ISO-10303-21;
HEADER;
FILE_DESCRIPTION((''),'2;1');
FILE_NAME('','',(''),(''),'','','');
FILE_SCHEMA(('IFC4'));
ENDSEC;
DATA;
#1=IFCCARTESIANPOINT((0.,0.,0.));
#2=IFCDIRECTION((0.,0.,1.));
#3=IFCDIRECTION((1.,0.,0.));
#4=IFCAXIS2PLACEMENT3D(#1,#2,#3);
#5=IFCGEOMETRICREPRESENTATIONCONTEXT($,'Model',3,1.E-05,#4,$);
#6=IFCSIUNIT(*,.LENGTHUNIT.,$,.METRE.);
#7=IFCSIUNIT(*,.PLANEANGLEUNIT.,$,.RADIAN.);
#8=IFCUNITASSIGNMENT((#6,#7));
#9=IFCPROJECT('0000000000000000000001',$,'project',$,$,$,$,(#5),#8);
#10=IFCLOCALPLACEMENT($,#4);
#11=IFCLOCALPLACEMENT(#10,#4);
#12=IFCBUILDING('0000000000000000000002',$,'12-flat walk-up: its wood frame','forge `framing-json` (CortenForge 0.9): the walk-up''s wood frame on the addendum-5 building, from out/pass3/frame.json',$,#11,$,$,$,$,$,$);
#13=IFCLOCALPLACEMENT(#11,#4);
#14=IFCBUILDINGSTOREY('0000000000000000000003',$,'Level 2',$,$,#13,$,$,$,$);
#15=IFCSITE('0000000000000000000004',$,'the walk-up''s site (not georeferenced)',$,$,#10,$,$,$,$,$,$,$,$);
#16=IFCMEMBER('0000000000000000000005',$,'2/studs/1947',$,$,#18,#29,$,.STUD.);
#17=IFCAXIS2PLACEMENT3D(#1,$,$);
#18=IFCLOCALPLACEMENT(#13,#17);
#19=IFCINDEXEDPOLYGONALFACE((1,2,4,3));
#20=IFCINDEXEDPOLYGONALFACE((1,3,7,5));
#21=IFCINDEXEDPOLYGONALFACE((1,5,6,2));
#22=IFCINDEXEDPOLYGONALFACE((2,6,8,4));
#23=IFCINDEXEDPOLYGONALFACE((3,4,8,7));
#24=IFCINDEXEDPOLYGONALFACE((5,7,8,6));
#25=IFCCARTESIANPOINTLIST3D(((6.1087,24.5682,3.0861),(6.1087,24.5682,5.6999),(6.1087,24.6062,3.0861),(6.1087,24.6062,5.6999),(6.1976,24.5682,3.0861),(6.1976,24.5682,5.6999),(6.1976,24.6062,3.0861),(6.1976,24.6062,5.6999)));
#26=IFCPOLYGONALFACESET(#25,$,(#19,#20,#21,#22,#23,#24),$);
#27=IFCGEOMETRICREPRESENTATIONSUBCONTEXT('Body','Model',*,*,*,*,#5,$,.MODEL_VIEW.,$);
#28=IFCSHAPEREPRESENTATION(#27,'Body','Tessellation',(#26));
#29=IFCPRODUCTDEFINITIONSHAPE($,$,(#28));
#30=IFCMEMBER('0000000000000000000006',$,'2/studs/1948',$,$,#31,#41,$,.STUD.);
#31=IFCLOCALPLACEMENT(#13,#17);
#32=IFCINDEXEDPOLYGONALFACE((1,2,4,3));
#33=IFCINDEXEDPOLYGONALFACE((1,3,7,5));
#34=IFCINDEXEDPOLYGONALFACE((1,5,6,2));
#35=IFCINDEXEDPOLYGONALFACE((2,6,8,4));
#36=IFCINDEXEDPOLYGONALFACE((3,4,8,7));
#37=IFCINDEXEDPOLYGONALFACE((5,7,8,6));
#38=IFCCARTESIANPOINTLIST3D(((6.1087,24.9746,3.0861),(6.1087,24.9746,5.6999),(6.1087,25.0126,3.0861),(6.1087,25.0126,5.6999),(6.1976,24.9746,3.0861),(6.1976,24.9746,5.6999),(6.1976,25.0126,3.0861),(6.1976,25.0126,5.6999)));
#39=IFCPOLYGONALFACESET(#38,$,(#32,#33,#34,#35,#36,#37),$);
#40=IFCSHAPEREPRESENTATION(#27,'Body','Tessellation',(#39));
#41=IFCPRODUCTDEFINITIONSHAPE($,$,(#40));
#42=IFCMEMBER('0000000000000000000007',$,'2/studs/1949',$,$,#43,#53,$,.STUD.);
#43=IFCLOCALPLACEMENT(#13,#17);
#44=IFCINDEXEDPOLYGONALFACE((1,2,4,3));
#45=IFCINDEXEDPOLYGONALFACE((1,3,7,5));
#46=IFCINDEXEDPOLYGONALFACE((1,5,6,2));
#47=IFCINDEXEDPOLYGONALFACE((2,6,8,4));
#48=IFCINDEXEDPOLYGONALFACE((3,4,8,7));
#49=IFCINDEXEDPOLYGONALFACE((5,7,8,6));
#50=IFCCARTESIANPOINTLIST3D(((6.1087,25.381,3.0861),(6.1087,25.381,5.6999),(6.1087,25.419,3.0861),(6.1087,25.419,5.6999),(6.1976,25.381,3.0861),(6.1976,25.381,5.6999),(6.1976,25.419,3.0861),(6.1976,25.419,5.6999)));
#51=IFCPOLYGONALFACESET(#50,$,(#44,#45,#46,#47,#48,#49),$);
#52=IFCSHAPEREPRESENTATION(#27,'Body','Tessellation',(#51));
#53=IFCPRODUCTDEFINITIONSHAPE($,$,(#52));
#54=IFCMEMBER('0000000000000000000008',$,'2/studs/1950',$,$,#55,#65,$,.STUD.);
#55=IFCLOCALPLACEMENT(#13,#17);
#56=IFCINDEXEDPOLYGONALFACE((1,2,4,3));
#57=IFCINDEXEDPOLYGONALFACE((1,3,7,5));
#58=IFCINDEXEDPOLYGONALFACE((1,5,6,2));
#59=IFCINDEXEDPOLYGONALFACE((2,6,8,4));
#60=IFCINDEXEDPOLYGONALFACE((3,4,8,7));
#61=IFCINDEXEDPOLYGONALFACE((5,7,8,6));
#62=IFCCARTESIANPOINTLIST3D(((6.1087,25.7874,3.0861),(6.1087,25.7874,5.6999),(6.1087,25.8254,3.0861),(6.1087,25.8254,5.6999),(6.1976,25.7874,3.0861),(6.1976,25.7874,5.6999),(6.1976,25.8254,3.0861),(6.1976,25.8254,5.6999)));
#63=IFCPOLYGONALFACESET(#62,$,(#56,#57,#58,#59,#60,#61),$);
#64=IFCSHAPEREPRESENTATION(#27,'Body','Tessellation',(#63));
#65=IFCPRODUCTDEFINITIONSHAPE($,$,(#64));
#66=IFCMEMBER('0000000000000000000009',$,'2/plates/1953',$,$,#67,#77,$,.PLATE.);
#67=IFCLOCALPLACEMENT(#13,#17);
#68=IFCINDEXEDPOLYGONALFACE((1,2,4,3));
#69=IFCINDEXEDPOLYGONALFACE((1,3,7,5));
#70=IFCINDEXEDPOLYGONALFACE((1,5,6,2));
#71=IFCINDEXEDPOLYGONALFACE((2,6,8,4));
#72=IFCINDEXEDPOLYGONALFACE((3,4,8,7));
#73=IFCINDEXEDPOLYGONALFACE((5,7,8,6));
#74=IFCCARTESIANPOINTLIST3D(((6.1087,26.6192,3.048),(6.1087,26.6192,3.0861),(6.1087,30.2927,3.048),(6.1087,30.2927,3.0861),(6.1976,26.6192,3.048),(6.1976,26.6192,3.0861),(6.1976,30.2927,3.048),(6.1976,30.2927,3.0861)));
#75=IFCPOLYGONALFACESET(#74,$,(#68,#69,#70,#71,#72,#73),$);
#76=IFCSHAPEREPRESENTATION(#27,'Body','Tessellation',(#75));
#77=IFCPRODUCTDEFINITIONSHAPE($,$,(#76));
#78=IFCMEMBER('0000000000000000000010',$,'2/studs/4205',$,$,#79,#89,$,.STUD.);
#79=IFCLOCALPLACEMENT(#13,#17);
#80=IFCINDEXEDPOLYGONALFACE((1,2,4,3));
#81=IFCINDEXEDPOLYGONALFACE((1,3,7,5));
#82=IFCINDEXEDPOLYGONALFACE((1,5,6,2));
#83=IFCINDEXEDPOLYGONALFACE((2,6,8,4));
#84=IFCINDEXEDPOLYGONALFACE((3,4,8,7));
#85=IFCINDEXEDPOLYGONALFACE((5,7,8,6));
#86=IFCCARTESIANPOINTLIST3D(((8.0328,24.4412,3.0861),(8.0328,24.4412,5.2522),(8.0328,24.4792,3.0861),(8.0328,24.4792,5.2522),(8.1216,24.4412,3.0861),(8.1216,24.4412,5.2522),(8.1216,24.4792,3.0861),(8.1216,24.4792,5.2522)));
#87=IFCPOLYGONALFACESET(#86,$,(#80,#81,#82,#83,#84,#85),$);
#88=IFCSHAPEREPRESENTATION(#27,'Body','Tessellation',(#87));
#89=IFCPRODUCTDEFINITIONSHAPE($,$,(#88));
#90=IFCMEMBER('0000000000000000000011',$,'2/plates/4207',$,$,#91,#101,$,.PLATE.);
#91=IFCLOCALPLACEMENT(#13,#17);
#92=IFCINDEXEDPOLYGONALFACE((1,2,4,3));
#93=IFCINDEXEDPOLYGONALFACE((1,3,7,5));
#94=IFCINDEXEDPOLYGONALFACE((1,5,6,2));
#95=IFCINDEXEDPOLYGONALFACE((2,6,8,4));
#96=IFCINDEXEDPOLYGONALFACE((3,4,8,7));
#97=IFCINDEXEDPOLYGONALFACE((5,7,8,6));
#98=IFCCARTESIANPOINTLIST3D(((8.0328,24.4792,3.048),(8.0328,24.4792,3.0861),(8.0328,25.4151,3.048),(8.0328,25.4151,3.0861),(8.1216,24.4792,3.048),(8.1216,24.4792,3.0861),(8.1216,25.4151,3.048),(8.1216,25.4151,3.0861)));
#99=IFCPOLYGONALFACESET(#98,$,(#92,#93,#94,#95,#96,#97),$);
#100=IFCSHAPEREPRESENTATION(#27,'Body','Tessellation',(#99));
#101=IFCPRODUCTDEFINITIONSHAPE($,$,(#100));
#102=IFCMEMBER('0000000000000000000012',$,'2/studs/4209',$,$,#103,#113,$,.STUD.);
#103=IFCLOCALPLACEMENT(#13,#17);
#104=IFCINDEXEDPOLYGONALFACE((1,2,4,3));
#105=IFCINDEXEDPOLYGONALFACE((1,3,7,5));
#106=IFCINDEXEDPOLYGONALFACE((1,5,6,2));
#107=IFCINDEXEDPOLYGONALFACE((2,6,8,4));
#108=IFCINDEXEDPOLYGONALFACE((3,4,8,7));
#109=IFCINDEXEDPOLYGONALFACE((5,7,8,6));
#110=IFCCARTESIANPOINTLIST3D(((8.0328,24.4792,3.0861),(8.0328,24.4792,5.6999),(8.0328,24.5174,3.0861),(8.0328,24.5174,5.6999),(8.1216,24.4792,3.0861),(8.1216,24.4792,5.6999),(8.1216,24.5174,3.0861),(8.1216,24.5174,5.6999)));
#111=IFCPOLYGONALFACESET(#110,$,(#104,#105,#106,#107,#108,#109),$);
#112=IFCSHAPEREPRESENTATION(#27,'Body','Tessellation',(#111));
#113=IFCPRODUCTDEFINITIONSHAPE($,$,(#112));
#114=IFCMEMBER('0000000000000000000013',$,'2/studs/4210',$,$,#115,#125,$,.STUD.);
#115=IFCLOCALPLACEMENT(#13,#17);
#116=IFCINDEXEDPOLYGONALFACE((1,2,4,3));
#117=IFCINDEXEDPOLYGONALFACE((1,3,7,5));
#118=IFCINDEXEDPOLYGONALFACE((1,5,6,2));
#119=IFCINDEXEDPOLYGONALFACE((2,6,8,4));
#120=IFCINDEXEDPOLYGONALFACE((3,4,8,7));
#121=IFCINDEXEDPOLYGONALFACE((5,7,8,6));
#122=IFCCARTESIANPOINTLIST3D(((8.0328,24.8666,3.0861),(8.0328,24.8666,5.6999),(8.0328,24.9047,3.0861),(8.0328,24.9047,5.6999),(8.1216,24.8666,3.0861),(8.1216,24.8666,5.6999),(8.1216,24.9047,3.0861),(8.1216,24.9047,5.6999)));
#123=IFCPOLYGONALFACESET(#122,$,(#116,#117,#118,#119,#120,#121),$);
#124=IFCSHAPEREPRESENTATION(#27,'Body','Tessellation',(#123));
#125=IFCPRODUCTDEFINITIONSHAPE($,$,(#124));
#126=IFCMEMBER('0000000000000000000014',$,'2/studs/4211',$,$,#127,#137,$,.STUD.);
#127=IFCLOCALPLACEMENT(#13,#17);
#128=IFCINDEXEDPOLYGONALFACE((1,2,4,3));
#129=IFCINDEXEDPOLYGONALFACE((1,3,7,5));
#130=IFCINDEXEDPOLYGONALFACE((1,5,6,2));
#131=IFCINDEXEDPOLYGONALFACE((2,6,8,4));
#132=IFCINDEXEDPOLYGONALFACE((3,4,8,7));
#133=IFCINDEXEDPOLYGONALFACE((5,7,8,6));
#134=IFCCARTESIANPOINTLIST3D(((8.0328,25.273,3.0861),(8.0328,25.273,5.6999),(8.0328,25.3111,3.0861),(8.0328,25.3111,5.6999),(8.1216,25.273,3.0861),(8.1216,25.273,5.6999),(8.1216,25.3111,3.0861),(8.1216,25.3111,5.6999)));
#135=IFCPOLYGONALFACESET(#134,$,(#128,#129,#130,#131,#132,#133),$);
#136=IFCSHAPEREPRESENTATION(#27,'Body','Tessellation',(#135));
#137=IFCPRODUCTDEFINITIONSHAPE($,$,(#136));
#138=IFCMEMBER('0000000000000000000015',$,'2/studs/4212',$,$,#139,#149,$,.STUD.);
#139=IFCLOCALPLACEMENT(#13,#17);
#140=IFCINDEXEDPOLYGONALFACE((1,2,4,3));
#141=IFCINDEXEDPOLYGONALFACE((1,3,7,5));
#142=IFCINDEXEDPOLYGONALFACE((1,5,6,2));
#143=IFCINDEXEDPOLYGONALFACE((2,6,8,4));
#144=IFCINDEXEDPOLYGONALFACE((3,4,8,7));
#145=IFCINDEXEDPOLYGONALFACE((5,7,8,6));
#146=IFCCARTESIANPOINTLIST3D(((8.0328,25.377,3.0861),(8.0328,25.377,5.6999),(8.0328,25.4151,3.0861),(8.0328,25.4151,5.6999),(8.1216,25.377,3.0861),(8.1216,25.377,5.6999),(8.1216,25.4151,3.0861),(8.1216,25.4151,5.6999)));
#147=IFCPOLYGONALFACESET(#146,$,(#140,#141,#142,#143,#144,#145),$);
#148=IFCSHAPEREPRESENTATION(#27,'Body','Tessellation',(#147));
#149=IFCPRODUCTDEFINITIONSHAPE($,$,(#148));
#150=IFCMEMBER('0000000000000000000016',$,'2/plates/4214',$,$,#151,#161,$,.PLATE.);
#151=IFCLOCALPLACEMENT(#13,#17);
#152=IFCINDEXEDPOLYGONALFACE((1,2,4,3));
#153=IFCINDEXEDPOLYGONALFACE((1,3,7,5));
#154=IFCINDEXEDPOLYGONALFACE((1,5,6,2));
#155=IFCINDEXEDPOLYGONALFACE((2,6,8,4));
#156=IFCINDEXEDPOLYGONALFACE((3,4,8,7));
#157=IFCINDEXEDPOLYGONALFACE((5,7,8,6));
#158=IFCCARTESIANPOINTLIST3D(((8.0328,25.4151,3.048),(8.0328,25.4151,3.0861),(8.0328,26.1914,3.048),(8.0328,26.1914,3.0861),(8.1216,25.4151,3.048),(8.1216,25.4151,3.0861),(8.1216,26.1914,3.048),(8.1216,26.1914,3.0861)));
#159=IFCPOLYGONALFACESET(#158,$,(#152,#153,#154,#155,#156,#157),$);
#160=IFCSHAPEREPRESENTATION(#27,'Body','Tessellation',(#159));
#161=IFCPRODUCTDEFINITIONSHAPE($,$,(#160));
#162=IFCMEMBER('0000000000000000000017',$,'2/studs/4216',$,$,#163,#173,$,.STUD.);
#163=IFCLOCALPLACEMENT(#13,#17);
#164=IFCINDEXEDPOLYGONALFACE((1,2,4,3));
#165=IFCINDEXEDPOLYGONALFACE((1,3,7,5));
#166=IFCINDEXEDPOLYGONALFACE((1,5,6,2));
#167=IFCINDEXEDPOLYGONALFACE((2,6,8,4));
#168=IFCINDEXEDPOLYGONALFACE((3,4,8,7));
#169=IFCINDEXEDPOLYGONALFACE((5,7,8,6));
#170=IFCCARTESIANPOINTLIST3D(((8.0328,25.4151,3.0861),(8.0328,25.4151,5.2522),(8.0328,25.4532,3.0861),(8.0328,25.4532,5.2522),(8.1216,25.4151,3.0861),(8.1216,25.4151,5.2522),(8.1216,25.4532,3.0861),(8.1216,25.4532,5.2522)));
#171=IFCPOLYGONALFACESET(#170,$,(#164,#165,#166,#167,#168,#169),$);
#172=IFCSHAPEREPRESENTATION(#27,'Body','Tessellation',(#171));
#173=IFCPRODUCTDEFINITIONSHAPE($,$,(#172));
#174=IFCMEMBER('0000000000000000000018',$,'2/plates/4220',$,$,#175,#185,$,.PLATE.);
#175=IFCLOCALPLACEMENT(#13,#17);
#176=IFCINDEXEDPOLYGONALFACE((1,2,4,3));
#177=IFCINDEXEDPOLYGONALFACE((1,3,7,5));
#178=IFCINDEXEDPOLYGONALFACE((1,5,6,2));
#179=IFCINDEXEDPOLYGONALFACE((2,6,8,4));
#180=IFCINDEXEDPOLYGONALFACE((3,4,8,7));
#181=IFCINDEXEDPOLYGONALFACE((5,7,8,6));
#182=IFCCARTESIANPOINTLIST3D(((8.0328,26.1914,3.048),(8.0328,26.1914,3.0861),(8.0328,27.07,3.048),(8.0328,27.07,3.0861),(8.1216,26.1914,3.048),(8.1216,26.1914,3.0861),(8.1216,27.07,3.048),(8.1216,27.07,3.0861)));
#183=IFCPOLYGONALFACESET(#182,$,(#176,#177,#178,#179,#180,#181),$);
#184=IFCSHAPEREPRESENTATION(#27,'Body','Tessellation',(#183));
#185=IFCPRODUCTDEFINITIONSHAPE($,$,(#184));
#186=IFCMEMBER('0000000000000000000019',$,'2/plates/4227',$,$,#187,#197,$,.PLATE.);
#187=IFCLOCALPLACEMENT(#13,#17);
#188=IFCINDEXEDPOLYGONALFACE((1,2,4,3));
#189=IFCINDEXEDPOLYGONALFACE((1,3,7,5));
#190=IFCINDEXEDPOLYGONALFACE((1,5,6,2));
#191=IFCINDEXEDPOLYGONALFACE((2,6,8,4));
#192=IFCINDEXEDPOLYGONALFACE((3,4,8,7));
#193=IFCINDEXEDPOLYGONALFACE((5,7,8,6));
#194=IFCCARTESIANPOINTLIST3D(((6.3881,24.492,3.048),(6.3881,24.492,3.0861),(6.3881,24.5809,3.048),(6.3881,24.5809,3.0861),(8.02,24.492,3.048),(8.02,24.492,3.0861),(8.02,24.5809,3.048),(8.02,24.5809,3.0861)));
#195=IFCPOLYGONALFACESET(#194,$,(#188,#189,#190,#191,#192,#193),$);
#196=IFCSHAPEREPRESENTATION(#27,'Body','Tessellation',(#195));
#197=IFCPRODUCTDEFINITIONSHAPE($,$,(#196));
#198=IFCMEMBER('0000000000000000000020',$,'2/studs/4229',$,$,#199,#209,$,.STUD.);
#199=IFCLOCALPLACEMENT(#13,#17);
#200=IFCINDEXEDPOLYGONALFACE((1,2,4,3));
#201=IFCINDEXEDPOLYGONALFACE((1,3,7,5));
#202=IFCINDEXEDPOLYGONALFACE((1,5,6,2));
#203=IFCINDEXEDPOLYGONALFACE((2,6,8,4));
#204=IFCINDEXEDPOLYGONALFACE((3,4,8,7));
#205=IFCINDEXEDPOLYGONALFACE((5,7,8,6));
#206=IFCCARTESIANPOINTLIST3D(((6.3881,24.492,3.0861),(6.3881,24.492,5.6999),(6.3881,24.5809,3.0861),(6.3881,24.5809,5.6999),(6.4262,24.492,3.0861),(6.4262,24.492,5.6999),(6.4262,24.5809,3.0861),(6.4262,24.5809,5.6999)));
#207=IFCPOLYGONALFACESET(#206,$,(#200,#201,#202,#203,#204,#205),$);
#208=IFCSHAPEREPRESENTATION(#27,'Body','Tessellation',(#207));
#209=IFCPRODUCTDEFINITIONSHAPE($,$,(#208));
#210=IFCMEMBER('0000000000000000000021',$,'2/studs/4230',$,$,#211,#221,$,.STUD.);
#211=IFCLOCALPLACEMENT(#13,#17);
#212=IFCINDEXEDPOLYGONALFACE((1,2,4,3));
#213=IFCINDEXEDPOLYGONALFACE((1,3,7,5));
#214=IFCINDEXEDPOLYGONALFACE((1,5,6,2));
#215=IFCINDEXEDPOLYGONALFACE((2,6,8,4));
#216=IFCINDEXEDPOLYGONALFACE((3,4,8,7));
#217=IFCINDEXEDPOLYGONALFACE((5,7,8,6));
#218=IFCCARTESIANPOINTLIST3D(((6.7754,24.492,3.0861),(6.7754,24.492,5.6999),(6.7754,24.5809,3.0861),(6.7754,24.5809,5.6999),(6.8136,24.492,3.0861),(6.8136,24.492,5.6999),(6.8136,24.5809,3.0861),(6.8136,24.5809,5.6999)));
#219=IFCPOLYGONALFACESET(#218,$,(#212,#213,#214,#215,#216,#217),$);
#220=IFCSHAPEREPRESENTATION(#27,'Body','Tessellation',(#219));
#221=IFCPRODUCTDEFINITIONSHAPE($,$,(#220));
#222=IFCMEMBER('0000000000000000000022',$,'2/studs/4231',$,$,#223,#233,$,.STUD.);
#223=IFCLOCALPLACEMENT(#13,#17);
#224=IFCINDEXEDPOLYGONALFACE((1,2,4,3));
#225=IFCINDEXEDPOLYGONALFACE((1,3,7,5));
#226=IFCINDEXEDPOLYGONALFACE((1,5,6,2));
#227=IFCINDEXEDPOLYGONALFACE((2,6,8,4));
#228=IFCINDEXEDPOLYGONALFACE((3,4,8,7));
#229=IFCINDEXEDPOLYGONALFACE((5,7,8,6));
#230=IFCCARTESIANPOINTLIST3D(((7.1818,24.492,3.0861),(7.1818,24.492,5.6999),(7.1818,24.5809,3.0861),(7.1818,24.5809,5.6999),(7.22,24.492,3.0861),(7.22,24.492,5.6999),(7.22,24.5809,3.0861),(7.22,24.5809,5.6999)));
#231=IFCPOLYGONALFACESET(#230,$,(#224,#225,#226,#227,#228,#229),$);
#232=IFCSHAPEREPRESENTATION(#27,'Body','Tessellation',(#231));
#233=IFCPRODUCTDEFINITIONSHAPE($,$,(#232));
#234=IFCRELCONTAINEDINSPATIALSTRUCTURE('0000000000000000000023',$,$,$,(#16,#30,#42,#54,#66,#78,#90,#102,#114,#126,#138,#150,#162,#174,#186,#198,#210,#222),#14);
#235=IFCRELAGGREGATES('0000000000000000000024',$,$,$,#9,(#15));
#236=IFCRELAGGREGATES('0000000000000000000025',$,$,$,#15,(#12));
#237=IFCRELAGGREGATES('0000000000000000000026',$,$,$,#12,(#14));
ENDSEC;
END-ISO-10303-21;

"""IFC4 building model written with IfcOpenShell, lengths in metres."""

from ifc_helpers import new_model, si_unit, frame, frame_2d, origin, origin_with_axes, place, context, subcontext, project, spatial, rectangle, extrude, element, save


model = new_model("IFC4")

# Units and contexts
model_context = context("Model", 3, precision=1e-05, world=origin_with_axes())
body_context = subcontext(model_context, "Body", "Model", "MODEL_VIEW")
ifc_project = project(units=[si_unit("LENGTHUNIT", "METRE"), si_unit("PLANEANGLEUNIT", "RADIAN")], contexts=[model_context])

# Site, building, storey
site_placement = place(None, origin_with_axes())
site = spatial("IfcSite", under=ifc_project, at=site_placement, Name="the walk-up's site (not georeferenced)")
building_placement = place(site_placement, origin_with_axes())
building = spatial("IfcBuilding", under=site, at=building_placement, Name="12-flat walk-up: its wood frame", Description="forge `framing-json` (CortenForge 0.9): the walk-up's wood frame on the addendum-5 building, from out/pass3/frame.json")
storey_placement = place(building_placement, origin_with_axes())
storey = spatial("IfcBuildingStorey", under=building, at=storey_placement, Name="Level 2")

# Members
for number, where, z_axis, x_axis, name in (
    (1, (6.1087, 24.5681, 3.0861), (0.0, 0.0, 1.0), (1.0, 0.0, 0.0), "2/studs/1947"),
    (2, (6.1087, 24.9746, 3.0861), (0.0, 0.0, 1.0), (1.0, 0.0, 0.0), "2/studs/1948"),
    (3, (6.1087, 25.3809, 3.0861), (0.0, 0.0, 1.0), (1.0, 0.0, 0.0), "2/studs/1949"),
    (4, (6.1087, 25.7873, 3.0861), (0.0, 0.0, 1.0), (1.0, 0.0, 0.0), "2/studs/1950"),
):
    element("IfcMember", number, at=place(storey_placement, frame(where, z_axis=z_axis, x_axis=x_axis)), inside=storey, Name=name, PredefinedType="STUD", context=body_context, shape_type="SweptSolid", body=[
        extrude(rectangle(XDim=0.0889, YDim=0.0381, at=frame_2d((0.0445, 0.0191))), origin(), (0.0, 0.0, 1.0), 2.6138),
    ])
member_1_placement = place(storey_placement, frame((6.1087, 26.6192, 3.048), z_axis=(0.0, 0.0, 1.0), x_axis=(1.0, 0.0, 0.0)))
element("IfcMember", 5, at=member_1_placement, inside=storey, Name="2/plates/1953", PredefinedType="PLATE", context=body_context, shape_type="SweptSolid", body=[
    extrude(rectangle(XDim=0.0889, YDim=3.6735, at=frame_2d((0.0445, 1.8367))), origin(), (0.0, 0.0, 1.0), 0.0381),
])
member_2_placement = place(storey_placement, frame((8.0328, 24.4412, 3.0861), z_axis=(0.0, 0.0, 1.0), x_axis=(1.0, 0.0, 0.0)))
element("IfcMember", 6, at=member_2_placement, inside=storey, Name="2/studs/4205", PredefinedType="STUD", context=body_context, shape_type="SweptSolid", body=[
    extrude(rectangle(XDim=0.0889, YDim=0.0381, at=frame_2d((0.0445, 0.0191))), origin(), (0.0, 0.0, 1.0), 2.1661),
])
member_3_placement = place(storey_placement, frame((8.0328, 24.4793, 3.048), z_axis=(0.0, 0.0, 1.0), x_axis=(1.0, 0.0, 0.0)))
element("IfcMember", 7, at=member_3_placement, inside=storey, Name="2/plates/4207", PredefinedType="PLATE", context=body_context, shape_type="SweptSolid", body=[
    extrude(rectangle(XDim=0.0889, YDim=0.9358, at=frame_2d((0.0445, 0.4679))), origin(), (0.0, 0.0, 1.0), 0.0381),
])
for number, where, z_axis, x_axis, name in (
    (8, (8.0328, 24.4793, 3.0861), (0.0, 0.0, 1.0), (1.0, 0.0, 0.0), "2/studs/4209"),
    (9, (8.0328, 24.8666, 3.0861), (0.0, 0.0, 1.0), (1.0, 0.0, 0.0), "2/studs/4210"),
    (10, (8.0328, 25.273, 3.0861), (0.0, 0.0, 1.0), (1.0, 0.0, 0.0), "2/studs/4211"),
    (11, (8.0328, 25.377, 3.0861), (0.0, 0.0, 1.0), (1.0, 0.0, 0.0), "2/studs/4212"),
):
    element("IfcMember", number, at=place(storey_placement, frame(where, z_axis=z_axis, x_axis=x_axis)), inside=storey, Name=name, PredefinedType="STUD", context=body_context, shape_type="SweptSolid", body=[
        extrude(rectangle(XDim=0.0889, YDim=0.0381, at=frame_2d((0.0445, 0.0191))), origin(), (0.0, 0.0, 1.0), 2.6138),
    ])
member_4_placement = place(storey_placement, frame((8.0328, 25.4151, 3.048), z_axis=(0.0, 0.0, 1.0), x_axis=(1.0, 0.0, 0.0)))
element("IfcMember", 12, at=member_4_placement, inside=storey, Name="2/plates/4214", PredefinedType="PLATE", context=body_context, shape_type="SweptSolid", body=[
    extrude(rectangle(XDim=0.0889, YDim=0.7763, at=frame_2d((0.0445, 0.3881))), origin(), (0.0, 0.0, 1.0), 0.0381),
])
member_5_placement = place(storey_placement, frame((8.0328, 25.4151, 3.0861), z_axis=(0.0, 0.0, 1.0), x_axis=(1.0, 0.0, 0.0)))
element("IfcMember", 13, at=member_5_placement, inside=storey, Name="2/studs/4216", PredefinedType="STUD", context=body_context, shape_type="SweptSolid", body=[
    extrude(rectangle(XDim=0.0889, YDim=0.0381, at=frame_2d((0.0445, 0.0191))), origin(), (0.0, 0.0, 1.0), 2.1661),
])
member_6_placement = place(storey_placement, frame((8.0328, 26.1914, 3.048), z_axis=(0.0, 0.0, 1.0), x_axis=(1.0, 0.0, 0.0)))
element("IfcMember", 14, at=member_6_placement, inside=storey, Name="2/plates/4220", PredefinedType="PLATE", context=body_context, shape_type="SweptSolid", body=[
    extrude(rectangle(XDim=0.0889, YDim=0.8787, at=frame_2d((0.0445, 0.4393))), origin(), (0.0, 0.0, 1.0), 0.0381),
])
member_7_placement = place(storey_placement, frame((6.3881, 24.4919, 3.048), z_axis=(0.0, 0.0, 1.0), x_axis=(1.0, 0.0, 0.0)))
element("IfcMember", 15, at=member_7_placement, inside=storey, Name="2/plates/4227", PredefinedType="PLATE", context=body_context, shape_type="SweptSolid", body=[
    extrude(rectangle(XDim=1.6319, YDim=0.0889, at=frame_2d((0.816, 0.0445))), origin(), (0.0, 0.0, 1.0), 0.0381),
])
for number, where, z_axis, x_axis, name in (
    (16, (6.3881, 24.4919, 3.0861), (0.0, 0.0, 1.0), (1.0, 0.0, 0.0), "2/studs/4229"),
    (17, (6.7755, 24.4919, 3.0861), (0.0, 0.0, 1.0), (1.0, 0.0, 0.0), "2/studs/4230"),
    (18, (7.1818, 24.4919, 3.0861), (0.0, 0.0, 1.0), (1.0, 0.0, 0.0), "2/studs/4231"),
):
    element("IfcMember", number, at=place(storey_placement, frame(where, z_axis=z_axis, x_axis=x_axis)), inside=storey, Name=name, PredefinedType="STUD", context=body_context, shape_type="SweptSolid", body=[
        extrude(rectangle(XDim=0.0381, YDim=0.0889, at=frame_2d((0.0191, 0.0445))), origin(), (0.0, 0.0, 1.0), 2.6138),
    ])

save(model, "model.ifc")
